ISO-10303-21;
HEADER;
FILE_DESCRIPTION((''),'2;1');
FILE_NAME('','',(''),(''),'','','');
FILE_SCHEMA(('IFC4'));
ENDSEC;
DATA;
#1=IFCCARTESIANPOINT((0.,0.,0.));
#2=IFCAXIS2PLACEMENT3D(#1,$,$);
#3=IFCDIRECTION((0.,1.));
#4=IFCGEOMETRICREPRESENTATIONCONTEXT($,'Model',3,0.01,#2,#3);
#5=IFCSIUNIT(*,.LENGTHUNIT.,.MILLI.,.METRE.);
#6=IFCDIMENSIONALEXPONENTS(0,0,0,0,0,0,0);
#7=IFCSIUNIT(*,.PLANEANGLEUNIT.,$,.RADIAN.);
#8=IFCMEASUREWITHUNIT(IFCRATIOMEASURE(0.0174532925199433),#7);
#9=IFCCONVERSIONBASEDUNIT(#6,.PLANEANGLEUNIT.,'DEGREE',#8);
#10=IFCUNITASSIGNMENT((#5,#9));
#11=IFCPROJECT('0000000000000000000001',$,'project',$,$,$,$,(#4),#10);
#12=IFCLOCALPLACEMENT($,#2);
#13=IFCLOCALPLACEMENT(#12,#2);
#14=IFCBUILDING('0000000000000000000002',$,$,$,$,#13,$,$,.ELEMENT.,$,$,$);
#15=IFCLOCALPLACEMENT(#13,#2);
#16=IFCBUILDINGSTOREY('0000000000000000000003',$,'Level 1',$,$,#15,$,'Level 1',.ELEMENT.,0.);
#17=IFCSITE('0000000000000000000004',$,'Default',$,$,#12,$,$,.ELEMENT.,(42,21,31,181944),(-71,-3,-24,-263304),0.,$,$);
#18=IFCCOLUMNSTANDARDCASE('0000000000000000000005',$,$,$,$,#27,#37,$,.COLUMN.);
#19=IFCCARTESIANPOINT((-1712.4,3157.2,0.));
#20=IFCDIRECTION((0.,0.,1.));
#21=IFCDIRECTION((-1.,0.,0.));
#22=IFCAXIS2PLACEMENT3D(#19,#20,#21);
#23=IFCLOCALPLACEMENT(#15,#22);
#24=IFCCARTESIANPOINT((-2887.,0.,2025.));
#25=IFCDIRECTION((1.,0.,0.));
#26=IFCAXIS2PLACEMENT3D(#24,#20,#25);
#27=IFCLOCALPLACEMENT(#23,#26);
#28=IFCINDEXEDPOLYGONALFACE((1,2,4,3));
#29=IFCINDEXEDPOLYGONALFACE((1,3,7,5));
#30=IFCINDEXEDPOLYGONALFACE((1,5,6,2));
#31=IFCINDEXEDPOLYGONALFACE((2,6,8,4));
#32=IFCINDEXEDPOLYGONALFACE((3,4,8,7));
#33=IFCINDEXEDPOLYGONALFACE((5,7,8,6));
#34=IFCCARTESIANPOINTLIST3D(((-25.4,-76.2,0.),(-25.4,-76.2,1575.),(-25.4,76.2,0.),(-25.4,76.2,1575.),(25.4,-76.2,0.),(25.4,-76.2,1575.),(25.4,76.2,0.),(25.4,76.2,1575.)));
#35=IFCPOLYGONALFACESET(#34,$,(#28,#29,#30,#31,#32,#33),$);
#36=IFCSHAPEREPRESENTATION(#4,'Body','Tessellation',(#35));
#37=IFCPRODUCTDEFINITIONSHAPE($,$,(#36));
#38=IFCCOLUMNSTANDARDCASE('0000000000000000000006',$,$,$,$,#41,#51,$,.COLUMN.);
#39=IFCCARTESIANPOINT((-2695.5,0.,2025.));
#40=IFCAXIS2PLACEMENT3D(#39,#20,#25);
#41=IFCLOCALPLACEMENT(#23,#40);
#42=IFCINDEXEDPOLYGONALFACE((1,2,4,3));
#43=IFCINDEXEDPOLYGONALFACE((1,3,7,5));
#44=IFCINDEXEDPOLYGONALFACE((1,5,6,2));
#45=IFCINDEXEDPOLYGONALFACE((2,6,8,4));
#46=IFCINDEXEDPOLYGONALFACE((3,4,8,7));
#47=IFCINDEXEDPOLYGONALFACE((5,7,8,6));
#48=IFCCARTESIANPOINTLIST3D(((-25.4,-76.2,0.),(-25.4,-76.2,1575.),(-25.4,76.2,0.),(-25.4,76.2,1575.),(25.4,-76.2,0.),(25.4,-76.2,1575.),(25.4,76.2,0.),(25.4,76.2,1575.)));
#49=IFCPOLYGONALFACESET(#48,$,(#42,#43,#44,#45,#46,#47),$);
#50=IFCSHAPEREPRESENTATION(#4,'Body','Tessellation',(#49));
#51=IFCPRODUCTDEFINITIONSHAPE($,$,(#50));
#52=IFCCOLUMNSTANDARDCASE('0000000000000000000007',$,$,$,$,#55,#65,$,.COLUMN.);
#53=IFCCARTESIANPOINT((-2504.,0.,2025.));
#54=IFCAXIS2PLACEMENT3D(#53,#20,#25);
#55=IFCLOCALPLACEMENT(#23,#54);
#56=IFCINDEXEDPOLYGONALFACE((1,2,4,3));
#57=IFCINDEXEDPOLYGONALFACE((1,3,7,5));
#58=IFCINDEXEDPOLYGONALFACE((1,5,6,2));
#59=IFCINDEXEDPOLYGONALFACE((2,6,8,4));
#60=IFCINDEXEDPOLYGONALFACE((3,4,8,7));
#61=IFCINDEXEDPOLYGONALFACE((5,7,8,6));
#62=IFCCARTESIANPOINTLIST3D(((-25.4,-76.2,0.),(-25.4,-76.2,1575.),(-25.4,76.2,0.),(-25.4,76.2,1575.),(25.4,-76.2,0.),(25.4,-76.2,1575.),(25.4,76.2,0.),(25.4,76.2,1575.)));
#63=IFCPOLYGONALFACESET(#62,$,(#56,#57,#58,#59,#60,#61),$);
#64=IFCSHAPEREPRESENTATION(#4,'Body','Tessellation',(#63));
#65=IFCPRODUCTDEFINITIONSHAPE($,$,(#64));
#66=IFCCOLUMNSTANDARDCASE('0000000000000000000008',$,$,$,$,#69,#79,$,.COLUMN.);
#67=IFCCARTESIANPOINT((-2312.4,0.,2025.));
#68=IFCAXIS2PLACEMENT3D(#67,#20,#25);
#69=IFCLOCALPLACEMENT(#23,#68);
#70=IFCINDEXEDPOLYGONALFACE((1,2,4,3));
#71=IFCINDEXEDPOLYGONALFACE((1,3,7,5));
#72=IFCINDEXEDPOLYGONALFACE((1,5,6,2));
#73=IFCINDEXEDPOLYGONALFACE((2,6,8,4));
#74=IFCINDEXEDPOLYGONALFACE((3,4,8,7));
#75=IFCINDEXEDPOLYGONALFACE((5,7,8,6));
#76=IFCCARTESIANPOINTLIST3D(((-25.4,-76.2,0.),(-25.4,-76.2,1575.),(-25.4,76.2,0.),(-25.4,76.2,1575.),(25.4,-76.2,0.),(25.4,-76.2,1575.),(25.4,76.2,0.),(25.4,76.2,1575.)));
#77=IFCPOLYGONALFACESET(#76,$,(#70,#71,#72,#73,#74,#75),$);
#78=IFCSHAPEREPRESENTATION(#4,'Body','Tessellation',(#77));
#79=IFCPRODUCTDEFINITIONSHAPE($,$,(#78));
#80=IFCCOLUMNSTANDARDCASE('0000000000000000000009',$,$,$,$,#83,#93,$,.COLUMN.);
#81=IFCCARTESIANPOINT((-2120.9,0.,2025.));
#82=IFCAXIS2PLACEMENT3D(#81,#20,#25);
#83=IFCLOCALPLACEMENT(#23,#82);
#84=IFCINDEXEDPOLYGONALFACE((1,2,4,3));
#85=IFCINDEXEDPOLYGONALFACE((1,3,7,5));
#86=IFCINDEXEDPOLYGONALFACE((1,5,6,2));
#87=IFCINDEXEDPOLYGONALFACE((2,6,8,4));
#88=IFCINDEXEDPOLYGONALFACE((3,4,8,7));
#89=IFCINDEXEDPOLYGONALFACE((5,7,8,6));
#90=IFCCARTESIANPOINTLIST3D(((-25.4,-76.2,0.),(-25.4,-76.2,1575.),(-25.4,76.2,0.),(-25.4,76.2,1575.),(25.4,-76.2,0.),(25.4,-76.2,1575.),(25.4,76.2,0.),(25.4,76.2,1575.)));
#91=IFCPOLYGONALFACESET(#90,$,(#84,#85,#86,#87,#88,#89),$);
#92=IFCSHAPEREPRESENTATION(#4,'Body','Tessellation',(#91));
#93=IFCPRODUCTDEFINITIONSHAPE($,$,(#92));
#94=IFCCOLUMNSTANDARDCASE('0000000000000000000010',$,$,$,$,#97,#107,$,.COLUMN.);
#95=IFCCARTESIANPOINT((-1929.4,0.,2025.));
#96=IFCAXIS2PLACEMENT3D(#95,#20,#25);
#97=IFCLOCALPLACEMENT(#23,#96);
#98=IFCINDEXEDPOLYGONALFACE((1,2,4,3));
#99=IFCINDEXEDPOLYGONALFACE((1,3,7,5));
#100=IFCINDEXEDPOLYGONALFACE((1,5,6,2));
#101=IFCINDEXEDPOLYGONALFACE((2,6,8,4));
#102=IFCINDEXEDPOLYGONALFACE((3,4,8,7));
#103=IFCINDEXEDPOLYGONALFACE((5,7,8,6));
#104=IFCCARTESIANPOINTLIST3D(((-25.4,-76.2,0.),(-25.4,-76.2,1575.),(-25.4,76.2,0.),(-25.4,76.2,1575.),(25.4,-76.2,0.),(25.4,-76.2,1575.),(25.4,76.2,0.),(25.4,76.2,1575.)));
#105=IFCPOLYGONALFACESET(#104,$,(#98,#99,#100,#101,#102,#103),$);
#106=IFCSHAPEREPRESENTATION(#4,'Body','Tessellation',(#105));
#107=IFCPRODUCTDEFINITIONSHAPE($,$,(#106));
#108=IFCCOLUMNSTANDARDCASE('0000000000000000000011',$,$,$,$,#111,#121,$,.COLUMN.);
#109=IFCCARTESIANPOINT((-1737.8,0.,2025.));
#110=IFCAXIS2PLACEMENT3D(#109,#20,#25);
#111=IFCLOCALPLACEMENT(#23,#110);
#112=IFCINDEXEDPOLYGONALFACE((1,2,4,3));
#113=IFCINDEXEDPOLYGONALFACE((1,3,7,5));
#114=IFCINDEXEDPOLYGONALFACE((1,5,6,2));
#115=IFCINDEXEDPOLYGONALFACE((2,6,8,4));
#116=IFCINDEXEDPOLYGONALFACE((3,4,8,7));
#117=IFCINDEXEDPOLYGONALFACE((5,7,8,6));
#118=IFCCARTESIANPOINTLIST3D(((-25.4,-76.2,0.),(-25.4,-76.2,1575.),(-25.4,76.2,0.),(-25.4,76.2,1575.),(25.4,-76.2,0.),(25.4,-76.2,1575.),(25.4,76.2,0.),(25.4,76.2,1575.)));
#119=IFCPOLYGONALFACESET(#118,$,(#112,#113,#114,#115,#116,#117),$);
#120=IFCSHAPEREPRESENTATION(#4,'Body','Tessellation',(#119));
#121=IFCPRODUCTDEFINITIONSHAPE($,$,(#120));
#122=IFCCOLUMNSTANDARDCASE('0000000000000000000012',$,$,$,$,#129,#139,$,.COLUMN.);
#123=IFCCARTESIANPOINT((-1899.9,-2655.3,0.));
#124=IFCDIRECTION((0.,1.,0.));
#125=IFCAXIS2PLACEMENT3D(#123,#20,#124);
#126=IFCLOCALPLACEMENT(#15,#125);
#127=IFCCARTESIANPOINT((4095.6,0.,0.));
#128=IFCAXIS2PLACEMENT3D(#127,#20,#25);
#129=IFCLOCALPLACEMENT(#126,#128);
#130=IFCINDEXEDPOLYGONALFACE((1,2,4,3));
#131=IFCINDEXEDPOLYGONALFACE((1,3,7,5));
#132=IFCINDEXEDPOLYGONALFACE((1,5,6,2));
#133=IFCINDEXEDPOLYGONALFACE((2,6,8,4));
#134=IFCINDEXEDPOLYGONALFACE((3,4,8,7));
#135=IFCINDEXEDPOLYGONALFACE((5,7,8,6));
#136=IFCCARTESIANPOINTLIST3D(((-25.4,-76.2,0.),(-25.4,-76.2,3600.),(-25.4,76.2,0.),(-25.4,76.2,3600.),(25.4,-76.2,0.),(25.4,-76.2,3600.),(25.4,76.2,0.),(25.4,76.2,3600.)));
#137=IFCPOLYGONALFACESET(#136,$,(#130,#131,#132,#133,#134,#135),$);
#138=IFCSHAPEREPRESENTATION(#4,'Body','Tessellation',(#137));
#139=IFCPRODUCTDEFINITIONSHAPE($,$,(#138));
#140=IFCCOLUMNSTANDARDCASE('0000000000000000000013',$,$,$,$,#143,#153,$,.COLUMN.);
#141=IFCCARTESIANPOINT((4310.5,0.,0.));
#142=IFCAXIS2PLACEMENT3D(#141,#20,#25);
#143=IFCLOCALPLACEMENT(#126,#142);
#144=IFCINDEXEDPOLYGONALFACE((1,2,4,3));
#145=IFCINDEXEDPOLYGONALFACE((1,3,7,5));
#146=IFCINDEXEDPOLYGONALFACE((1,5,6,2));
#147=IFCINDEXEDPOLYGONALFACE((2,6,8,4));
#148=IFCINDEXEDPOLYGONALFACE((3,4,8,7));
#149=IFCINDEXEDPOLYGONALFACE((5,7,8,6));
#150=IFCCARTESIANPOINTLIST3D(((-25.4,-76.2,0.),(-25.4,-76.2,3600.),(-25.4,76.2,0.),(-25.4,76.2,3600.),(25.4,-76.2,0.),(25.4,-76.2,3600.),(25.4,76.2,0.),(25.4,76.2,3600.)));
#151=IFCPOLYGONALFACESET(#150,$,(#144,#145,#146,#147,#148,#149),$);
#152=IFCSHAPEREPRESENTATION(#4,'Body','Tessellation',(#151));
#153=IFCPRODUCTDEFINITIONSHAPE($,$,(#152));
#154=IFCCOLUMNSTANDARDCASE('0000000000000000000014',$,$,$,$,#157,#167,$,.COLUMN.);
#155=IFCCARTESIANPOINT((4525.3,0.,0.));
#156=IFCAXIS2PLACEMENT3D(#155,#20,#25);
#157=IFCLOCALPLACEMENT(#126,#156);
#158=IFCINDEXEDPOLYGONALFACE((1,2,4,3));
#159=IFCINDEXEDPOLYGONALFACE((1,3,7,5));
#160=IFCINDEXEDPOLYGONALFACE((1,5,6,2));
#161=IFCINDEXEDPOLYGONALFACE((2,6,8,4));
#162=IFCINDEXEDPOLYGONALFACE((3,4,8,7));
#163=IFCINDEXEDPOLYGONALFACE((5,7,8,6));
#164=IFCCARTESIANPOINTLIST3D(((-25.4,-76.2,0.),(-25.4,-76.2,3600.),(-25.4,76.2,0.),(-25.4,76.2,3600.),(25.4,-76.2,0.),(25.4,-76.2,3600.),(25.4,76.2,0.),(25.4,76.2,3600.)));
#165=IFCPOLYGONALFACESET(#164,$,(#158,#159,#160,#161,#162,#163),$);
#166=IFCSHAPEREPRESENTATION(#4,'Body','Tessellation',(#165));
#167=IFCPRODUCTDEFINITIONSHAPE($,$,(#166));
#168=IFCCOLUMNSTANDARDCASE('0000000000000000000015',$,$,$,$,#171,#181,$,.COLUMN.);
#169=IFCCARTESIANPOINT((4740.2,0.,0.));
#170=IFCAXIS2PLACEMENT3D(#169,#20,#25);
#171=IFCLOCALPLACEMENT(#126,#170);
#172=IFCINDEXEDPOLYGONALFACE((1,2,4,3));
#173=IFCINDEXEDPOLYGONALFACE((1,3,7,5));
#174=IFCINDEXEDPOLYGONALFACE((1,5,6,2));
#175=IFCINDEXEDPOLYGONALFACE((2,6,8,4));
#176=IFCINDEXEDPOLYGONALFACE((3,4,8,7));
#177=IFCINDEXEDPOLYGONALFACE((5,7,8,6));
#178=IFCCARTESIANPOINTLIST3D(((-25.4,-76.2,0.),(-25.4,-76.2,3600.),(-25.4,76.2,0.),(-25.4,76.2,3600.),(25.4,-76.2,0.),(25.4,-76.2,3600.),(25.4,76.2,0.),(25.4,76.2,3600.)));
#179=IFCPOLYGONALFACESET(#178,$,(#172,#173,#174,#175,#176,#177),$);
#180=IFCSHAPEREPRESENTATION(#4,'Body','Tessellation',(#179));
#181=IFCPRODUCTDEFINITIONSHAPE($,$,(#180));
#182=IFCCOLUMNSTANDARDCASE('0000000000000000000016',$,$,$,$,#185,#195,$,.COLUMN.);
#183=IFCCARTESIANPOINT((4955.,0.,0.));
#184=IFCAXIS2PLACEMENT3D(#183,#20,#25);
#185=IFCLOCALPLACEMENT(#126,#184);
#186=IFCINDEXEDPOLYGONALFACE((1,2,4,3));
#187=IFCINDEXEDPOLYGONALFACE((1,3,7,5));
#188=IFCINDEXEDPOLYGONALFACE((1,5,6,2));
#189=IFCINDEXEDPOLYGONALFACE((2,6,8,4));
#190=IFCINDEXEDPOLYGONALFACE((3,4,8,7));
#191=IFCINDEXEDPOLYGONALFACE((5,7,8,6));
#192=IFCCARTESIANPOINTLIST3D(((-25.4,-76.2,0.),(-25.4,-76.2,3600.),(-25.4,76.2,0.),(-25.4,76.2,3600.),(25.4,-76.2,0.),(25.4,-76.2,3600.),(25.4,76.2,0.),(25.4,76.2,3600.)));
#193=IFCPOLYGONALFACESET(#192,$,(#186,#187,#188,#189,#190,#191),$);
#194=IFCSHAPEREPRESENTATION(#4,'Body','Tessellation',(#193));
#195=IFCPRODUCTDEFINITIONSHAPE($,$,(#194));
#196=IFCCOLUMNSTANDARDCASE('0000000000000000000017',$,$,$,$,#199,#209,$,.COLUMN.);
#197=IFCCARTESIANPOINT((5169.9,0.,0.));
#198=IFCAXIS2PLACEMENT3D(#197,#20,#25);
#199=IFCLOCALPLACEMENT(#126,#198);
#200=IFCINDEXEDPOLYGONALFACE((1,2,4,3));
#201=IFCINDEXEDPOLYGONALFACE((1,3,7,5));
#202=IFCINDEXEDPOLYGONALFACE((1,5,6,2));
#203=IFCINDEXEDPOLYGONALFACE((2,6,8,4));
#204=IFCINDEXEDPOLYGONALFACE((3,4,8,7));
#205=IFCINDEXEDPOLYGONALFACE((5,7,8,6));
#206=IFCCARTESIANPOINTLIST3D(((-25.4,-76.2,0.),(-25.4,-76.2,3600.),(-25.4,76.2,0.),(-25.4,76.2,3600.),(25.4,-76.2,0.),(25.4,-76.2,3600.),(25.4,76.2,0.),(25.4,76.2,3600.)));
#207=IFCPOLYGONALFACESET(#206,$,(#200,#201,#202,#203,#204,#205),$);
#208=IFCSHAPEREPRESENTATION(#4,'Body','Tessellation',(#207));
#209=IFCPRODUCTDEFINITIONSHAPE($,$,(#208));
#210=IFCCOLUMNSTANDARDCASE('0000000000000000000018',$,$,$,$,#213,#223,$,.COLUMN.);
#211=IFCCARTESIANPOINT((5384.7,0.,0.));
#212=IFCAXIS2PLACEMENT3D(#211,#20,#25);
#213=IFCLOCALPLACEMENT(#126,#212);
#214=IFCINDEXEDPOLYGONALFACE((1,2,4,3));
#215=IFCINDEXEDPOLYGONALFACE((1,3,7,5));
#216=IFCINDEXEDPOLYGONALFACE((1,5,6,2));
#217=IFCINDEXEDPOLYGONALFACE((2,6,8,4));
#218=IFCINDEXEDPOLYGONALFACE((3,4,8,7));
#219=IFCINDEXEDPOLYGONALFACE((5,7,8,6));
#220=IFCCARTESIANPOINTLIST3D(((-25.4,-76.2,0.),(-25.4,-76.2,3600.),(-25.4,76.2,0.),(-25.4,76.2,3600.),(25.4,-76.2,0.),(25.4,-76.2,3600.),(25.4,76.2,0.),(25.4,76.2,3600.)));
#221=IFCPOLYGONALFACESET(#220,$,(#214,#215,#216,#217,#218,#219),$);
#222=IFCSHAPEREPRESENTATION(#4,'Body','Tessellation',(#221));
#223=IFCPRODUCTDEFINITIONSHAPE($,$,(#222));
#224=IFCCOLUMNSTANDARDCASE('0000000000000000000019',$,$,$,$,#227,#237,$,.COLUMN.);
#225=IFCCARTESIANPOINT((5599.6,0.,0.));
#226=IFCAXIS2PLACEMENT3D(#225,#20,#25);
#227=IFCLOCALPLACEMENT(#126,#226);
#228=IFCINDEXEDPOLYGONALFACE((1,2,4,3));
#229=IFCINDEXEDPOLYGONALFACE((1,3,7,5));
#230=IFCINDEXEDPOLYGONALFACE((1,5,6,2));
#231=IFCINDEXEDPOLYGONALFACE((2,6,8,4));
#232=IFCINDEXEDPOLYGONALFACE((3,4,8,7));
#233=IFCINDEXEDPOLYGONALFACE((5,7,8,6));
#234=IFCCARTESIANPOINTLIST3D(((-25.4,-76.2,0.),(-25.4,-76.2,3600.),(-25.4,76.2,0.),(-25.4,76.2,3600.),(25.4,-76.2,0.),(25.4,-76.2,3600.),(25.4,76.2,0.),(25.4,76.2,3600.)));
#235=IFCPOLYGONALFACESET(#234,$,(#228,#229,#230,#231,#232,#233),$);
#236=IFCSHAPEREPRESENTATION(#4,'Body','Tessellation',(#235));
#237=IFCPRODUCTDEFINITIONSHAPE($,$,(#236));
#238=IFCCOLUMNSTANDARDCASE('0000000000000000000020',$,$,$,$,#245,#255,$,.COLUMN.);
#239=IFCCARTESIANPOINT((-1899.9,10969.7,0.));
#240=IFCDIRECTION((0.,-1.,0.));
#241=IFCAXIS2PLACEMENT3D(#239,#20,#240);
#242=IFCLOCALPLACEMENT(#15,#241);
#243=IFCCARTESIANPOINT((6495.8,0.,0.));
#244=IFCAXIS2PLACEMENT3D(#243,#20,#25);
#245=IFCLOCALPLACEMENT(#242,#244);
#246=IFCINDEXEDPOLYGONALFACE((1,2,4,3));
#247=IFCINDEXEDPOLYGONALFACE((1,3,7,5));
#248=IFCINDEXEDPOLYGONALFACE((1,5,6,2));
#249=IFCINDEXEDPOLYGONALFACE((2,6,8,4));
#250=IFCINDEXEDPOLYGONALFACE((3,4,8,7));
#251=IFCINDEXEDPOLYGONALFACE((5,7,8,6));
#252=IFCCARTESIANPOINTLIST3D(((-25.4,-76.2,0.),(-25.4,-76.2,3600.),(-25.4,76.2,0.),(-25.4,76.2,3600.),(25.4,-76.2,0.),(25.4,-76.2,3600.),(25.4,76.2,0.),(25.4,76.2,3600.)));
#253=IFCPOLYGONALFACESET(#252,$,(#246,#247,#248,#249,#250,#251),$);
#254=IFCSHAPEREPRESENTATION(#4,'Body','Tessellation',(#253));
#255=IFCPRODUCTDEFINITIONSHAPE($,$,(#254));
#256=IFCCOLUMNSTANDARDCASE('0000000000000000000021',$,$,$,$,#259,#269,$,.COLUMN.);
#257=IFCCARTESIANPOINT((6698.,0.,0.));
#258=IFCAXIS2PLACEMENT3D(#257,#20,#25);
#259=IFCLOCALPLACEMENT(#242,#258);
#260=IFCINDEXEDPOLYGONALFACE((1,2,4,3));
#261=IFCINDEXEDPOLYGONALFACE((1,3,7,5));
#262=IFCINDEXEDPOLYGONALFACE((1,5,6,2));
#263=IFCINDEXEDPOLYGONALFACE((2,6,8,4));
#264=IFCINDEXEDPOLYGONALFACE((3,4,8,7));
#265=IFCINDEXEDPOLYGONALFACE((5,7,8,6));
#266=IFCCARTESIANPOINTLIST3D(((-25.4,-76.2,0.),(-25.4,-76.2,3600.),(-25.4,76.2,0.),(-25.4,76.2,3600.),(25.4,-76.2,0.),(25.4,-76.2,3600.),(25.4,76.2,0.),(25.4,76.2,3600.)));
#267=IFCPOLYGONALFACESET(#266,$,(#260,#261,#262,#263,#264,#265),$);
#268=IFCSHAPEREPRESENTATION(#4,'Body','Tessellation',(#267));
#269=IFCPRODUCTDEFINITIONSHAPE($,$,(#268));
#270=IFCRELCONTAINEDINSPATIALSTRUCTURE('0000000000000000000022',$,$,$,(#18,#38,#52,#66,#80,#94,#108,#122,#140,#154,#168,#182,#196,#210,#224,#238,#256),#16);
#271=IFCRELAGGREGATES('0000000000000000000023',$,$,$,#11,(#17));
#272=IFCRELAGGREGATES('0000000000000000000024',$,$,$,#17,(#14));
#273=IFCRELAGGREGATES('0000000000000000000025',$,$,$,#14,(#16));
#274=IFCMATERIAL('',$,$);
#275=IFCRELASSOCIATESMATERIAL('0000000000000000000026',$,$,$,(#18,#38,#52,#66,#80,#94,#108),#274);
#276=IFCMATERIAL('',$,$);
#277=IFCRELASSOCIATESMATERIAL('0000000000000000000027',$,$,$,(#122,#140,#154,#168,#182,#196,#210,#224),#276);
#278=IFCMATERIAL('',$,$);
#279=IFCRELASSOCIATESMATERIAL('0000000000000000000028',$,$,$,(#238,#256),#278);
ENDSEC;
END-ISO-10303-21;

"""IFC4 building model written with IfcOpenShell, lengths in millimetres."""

from ifc_helpers import new_model, entity, si_unit, converted_unit, direction, frame, origin, place, context, project, spatial, rectangle, extrude, material, element, save


model = new_model("IFC4")

# Units and contexts
model_context = context("Model", 3, precision=0.01, world=origin(), true_north=direction((0.0, 1.0)))
ifc_project = project(units=[si_unit("LENGTHUNIT", "METRE", prefix="MILLI"), converted_unit("PLANEANGLEUNIT", "DEGREE", entity("IfcRatioMeasure", 0.0174532925199433), si_unit("PLANEANGLEUNIT", "RADIAN"), dimensions=[0, 0, 0, 0, 0, 0, 0])], contexts=[model_context])

# Site, building, storey
site_placement = place(None, origin())
site = spatial("IfcSite", under=ifc_project, at=site_placement, Name="Default", CompositionType="ELEMENT", RefLatitude=(42, 21, 31, 181944), RefLongitude=(-71, -3, -24, -263304), RefElevation=0.0)
building_placement = place(site_placement, origin())
building = spatial("IfcBuilding", under=site, at=building_placement, CompositionType="ELEMENT")
storey_placement = place(building_placement, origin())
storey = spatial("IfcBuildingStorey", under=building, at=storey_placement, Name="Level 1", LongName="Level 1", CompositionType="ELEMENT", Elevation=0.0)

# Columns
ifc_material_1 = material(Name="")
placement_1 = place(storey_placement, frame((-1712.4, 3157.2, 0.0), z_axis=(0.0, 0.0, 1.0), x_axis=(-1.0, 0.0, 0.0)))
ifc_material_2 = material(Name="")
for number, where, z_axis, x_axis in (
    (1, (-2887.0, 0.0, 2025.0), (0.0, 0.0, 1.0), (1.0, 0.0, 0.0)),
    (2, (-2695.5, 0.0, 2025.0), (0.0, 0.0, 1.0), (1.0, 0.0, 0.0)),
    (3, (-2504.0, 0.0, 2025.0), (0.0, 0.0, 1.0), (1.0, 0.0, 0.0)),
    (4, (-2312.4, 0.0, 2025.0), (0.0, 0.0, 1.0), (1.0, 0.0, 0.0)),
    (5, (-2120.9, 0.0, 2025.0), (0.0, 0.0, 1.0), (1.0, 0.0, 0.0)),
    (6, (-1929.4, 0.0, 2025.0), (0.0, 0.0, 1.0), (1.0, 0.0, 0.0)),
    (7, (-1737.8, 0.0, 2025.0), (0.0, 0.0, 1.0), (1.0, 0.0, 0.0)),
):
    element("IfcColumnStandardCase", number, at=place(placement_1, frame(where, z_axis=z_axis, x_axis=x_axis)), inside=storey, material=ifc_material_2, PredefinedType="COLUMN", context=model_context, shape_type="SweptSolid", body=[
        extrude(rectangle(XDim=50.8, YDim=152.4), origin(), (0.0, 0.0, 1.0), 1575.0),
    ])
ifc_material_3 = material(Name="")
placement_2 = place(storey_placement, frame((-1899.9, -2655.3, 0.0), z_axis=(0.0, 0.0, 1.0), x_axis=(0.0, 1.0, 0.0)))
for number, where, z_axis, x_axis in (
    (8, (4095.6, 0.0, 0.0), (0.0, 0.0, 1.0), (1.0, 0.0, 0.0)),
    (9, (4310.5, 0.0, 0.0), (0.0, 0.0, 1.0), (1.0, 0.0, 0.0)),
    (10, (4525.3, 0.0, 0.0), (0.0, 0.0, 1.0), (1.0, 0.0, 0.0)),
    (11, (4740.2, 0.0, 0.0), (0.0, 0.0, 1.0), (1.0, 0.0, 0.0)),
    (12, (4955.0, 0.0, 0.0), (0.0, 0.0, 1.0), (1.0, 0.0, 0.0)),
    (13, (5169.9, 0.0, 0.0), (0.0, 0.0, 1.0), (1.0, 0.0, 0.0)),
    (14, (5384.7, 0.0, 0.0), (0.0, 0.0, 1.0), (1.0, 0.0, 0.0)),
    (15, (5599.6, 0.0, 0.0), (0.0, 0.0, 1.0), (1.0, 0.0, 0.0)),
):
    element("IfcColumnStandardCase", number, at=place(placement_2, frame(where, z_axis=z_axis, x_axis=x_axis)), inside=storey, material=ifc_material_3, PredefinedType="COLUMN", context=model_context, shape_type="SweptSolid", body=[
        extrude(rectangle(XDim=50.8, YDim=152.4), origin(), (0.0, 0.0, 1.0), 3600.0),
    ])
placement_3 = place(storey_placement, frame((-1899.9, 10969.7, 0.0), z_axis=(0.0, 0.0, 1.0), x_axis=(0.0, -1.0, 0.0)))
for number, where, z_axis, x_axis in (
    (16, (6495.8, 0.0, 0.0), (0.0, 0.0, 1.0), (1.0, 0.0, 0.0)),
    (17, (6698.0, 0.0, 0.0), (0.0, 0.0, 1.0), (1.0, 0.0, 0.0)),
):
    element("IfcColumnStandardCase", number, at=place(placement_3, frame(where, z_axis=z_axis, x_axis=x_axis)), inside=storey, material=ifc_material_1, PredefinedType="COLUMN", context=model_context, shape_type="SweptSolid", body=[
        extrude(rectangle(XDim=50.8, YDim=152.4), origin(), (0.0, 0.0, 1.0), 3600.0),
    ])

save(model, "model.ifc")
